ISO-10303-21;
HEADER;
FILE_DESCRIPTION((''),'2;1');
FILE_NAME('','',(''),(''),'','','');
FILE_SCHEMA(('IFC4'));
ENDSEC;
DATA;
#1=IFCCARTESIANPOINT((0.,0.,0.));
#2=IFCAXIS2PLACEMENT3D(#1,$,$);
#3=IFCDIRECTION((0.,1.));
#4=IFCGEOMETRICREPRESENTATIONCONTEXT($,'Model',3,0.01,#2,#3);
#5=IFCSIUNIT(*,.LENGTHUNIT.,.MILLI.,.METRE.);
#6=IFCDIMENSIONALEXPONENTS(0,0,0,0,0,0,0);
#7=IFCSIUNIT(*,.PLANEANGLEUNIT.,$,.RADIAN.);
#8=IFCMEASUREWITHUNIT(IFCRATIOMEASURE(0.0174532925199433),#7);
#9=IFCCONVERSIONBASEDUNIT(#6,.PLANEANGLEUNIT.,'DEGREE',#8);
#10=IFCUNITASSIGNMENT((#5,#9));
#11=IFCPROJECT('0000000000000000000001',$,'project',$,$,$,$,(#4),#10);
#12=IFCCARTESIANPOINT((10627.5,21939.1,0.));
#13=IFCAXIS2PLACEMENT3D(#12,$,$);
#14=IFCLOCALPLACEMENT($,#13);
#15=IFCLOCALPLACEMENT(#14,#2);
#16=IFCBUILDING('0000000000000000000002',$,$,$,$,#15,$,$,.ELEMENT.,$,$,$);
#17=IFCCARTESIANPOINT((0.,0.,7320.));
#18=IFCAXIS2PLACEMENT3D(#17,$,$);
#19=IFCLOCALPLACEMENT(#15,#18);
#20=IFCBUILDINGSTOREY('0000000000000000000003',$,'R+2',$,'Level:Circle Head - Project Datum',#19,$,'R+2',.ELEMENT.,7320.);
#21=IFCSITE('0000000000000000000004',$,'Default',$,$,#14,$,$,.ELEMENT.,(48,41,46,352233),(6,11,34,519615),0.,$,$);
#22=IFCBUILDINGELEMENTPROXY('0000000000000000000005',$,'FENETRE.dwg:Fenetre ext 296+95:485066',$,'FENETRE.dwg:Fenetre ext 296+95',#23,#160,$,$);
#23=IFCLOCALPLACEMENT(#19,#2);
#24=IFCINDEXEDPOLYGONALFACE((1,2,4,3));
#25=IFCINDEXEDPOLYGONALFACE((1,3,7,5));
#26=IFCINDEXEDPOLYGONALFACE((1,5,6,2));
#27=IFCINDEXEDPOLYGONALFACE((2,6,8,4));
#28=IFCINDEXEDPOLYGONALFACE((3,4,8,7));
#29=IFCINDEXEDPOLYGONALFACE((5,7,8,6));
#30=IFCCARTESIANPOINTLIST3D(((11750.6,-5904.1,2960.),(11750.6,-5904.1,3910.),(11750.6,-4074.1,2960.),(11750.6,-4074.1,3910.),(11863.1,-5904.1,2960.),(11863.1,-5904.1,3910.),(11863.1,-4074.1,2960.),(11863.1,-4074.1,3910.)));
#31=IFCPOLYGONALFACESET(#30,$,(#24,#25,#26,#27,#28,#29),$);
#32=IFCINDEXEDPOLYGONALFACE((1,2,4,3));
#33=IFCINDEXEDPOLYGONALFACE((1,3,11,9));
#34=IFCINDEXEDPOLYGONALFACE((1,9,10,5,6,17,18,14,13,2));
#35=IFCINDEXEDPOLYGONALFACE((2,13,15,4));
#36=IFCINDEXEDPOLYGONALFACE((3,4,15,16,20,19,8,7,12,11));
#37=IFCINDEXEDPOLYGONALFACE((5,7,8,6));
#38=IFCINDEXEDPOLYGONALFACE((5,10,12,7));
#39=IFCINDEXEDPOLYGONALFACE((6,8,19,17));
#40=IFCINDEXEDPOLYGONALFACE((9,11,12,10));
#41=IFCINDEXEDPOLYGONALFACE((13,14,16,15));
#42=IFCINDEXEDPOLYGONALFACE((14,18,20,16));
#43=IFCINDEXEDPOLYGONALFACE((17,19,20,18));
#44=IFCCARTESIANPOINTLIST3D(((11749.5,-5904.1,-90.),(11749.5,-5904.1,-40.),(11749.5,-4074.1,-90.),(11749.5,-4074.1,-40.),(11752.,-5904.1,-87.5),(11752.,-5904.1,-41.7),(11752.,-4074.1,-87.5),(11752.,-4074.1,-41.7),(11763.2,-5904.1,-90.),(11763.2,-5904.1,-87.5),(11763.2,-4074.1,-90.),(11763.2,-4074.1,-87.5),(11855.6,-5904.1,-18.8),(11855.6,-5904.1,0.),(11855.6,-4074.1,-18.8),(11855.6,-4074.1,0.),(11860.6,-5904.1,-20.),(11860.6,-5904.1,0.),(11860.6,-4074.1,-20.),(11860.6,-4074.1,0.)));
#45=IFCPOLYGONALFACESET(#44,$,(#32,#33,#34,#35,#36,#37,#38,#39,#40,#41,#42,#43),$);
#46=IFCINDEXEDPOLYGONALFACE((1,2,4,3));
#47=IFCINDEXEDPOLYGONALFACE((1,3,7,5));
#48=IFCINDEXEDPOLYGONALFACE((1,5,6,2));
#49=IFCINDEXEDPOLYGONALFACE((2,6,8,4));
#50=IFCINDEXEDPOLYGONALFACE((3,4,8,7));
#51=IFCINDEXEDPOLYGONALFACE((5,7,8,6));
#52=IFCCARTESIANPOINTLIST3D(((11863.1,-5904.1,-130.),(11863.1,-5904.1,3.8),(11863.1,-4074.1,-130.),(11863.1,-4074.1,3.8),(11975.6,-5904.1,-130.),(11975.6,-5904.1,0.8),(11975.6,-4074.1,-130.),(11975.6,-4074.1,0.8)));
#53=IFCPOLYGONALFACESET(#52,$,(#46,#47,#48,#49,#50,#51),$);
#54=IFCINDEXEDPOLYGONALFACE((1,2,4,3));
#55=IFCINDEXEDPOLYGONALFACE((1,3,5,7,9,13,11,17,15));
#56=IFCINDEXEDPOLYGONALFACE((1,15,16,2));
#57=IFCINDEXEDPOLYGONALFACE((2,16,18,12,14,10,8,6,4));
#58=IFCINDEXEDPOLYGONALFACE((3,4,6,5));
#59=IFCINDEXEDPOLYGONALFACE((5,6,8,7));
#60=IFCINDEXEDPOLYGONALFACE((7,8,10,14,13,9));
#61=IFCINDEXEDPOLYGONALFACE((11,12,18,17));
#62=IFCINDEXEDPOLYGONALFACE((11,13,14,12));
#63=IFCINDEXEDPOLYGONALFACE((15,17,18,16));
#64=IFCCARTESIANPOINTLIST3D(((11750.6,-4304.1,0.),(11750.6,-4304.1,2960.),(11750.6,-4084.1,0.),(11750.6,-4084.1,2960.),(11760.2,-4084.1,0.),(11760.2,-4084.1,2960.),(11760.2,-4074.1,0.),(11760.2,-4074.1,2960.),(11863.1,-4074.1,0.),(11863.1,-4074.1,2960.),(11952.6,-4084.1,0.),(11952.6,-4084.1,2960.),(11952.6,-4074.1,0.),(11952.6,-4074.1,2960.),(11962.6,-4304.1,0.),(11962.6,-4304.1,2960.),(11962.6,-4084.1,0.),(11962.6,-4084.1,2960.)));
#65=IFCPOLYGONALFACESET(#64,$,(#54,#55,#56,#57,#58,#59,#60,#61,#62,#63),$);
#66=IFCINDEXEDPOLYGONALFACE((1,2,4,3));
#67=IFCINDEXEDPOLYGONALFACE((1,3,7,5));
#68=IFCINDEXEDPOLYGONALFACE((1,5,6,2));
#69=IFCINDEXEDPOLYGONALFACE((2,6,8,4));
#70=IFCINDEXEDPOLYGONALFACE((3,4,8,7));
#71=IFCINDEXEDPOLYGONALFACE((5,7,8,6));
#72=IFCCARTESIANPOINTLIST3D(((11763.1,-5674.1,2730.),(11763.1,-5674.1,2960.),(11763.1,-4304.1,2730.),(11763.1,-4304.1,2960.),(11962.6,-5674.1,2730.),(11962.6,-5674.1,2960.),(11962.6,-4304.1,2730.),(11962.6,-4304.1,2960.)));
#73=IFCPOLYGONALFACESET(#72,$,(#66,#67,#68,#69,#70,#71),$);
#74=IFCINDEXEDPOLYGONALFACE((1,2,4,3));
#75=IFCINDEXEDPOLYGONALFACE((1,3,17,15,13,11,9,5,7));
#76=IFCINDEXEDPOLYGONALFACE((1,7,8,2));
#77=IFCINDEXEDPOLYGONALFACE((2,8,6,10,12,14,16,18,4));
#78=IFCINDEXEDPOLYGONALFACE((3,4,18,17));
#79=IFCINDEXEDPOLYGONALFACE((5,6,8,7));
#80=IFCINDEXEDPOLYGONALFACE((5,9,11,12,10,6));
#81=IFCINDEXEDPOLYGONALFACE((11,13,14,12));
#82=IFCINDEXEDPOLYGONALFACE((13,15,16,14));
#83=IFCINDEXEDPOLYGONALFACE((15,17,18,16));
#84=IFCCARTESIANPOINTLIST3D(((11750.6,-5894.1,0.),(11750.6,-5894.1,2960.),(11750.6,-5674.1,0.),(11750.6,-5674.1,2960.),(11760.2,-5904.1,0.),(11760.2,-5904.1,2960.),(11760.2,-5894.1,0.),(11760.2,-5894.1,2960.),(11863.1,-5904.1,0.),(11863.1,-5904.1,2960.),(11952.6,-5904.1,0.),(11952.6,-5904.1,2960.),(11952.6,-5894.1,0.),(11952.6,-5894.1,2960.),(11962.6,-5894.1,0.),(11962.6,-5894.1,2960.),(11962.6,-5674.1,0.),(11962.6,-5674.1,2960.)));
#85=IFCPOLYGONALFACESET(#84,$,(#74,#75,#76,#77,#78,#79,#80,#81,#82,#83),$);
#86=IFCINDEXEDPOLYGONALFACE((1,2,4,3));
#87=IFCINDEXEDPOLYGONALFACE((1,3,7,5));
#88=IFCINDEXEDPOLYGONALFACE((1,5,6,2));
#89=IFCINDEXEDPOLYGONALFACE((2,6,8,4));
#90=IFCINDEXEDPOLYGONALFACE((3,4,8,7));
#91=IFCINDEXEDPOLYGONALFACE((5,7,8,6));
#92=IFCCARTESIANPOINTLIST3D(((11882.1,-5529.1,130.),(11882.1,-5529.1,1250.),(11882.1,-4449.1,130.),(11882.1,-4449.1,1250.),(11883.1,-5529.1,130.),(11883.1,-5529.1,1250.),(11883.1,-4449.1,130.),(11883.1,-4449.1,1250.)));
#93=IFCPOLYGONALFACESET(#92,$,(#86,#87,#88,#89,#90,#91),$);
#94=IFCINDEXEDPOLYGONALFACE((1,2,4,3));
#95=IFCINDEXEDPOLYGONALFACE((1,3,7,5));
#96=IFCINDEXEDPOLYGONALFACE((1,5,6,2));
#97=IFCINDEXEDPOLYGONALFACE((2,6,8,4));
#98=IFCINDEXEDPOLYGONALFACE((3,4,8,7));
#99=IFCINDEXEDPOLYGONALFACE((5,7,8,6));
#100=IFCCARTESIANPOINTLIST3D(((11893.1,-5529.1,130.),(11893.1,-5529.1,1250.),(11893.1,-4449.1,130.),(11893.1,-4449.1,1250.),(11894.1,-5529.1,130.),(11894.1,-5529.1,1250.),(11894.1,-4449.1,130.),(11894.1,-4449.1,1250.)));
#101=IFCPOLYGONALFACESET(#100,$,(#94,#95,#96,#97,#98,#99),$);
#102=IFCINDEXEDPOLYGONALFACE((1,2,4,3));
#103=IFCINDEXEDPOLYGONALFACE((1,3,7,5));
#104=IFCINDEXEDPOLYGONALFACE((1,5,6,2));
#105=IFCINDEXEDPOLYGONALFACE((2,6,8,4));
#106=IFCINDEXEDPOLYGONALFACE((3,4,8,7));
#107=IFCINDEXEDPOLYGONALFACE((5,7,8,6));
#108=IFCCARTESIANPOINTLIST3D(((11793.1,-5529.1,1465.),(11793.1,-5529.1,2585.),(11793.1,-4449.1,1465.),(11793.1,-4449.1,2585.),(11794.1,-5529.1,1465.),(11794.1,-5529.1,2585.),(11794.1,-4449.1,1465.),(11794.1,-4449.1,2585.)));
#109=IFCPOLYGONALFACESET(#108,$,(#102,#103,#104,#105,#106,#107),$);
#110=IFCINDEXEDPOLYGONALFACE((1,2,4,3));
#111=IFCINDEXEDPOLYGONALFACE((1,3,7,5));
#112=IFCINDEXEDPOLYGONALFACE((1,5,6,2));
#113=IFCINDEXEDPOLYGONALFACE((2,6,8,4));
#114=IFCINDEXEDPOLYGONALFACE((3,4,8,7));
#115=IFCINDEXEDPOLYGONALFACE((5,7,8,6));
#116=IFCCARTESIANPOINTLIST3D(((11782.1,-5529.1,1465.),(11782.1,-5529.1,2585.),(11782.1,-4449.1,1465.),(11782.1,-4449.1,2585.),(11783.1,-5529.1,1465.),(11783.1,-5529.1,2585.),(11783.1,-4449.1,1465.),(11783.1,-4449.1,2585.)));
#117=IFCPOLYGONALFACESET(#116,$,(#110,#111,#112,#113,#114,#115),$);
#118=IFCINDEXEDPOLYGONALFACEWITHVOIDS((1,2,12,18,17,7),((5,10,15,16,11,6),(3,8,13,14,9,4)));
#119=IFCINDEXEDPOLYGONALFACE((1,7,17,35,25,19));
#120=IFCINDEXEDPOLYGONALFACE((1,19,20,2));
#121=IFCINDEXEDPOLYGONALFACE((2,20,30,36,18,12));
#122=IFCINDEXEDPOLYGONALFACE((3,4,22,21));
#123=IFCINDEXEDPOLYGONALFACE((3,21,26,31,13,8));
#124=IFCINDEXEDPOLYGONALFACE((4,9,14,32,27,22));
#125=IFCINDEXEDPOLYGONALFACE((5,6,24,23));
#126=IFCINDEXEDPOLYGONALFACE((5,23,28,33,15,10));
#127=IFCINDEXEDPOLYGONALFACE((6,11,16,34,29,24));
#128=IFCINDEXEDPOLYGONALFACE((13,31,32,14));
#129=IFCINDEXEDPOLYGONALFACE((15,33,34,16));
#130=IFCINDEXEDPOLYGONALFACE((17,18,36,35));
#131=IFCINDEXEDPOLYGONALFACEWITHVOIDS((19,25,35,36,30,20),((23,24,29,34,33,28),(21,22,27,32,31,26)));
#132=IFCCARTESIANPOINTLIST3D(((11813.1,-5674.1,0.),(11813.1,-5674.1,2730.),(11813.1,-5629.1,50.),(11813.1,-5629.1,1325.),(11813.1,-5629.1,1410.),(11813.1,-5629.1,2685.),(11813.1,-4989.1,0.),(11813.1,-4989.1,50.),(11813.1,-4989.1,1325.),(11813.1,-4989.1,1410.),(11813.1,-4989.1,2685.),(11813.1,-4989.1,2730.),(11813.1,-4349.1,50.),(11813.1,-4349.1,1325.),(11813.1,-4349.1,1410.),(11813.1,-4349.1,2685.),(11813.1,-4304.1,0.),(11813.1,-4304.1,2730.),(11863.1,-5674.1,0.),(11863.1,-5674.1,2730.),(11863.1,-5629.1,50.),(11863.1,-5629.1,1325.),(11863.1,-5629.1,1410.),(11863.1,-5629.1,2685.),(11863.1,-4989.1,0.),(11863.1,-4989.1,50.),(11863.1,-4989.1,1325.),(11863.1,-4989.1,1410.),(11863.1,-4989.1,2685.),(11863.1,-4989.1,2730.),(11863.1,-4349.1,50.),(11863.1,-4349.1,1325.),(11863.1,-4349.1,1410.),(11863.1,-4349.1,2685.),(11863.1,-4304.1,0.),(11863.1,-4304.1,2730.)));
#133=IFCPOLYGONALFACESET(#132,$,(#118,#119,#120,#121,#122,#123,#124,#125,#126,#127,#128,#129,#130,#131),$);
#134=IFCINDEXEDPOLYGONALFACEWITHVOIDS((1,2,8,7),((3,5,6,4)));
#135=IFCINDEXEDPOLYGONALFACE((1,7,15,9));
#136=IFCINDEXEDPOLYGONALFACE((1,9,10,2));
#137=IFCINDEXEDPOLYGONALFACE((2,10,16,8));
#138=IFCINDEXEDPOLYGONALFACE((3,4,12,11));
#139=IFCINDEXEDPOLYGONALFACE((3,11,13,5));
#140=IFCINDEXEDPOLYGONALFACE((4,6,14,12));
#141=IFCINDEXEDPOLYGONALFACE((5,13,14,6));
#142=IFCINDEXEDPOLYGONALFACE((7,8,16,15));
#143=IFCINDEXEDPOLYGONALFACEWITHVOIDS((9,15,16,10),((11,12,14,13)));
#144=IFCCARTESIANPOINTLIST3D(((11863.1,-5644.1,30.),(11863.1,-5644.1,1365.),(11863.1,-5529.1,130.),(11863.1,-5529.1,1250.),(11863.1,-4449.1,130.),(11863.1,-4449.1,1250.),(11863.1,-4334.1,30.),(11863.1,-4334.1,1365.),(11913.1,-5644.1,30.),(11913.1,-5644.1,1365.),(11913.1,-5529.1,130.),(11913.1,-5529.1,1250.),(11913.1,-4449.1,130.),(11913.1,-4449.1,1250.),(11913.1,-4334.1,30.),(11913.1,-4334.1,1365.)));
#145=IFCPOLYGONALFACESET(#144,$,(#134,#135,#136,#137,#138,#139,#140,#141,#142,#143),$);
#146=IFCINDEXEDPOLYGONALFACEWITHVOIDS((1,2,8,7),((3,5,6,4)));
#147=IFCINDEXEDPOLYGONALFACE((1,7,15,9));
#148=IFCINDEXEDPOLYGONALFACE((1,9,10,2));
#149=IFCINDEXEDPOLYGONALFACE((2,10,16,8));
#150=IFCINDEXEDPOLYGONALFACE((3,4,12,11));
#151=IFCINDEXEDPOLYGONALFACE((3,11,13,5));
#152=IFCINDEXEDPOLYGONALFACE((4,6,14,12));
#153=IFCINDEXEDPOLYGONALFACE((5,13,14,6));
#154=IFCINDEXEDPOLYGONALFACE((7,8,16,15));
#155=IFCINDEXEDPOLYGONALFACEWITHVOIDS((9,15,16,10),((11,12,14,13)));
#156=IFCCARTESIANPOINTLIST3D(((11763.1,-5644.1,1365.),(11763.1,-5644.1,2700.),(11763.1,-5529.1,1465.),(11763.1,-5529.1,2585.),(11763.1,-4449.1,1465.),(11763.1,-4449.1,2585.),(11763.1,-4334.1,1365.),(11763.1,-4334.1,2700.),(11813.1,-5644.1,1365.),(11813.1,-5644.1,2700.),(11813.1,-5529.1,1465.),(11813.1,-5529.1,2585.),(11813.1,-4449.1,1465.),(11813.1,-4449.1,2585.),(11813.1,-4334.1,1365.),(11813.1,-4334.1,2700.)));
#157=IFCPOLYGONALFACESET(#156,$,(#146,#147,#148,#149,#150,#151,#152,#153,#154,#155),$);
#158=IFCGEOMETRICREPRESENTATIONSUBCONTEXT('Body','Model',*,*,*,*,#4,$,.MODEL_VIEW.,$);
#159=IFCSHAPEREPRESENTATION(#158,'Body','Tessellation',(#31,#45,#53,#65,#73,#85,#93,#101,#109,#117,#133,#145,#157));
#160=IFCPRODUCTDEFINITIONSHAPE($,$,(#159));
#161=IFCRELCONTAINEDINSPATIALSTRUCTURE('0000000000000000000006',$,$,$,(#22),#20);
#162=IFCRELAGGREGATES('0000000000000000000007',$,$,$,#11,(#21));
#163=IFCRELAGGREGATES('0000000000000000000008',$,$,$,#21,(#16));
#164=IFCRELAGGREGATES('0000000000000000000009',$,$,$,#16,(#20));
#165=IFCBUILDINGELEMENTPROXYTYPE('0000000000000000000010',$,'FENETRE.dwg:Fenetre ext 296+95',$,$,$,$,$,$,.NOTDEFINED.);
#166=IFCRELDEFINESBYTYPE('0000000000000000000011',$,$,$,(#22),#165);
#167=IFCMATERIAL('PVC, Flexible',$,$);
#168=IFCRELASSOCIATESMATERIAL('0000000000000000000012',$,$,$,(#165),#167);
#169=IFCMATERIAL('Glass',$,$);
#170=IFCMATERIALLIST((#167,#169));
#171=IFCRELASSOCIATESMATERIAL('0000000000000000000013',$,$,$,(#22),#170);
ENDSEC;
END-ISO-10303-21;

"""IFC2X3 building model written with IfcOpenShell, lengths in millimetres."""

from ifc_helpers import new_model, entity, si_unit, converted_unit, direction, frame, frame_2d, origin, origin_2d_with_axis, place, context, subcontext, project, spatial, polyline, rectangle, outline, extrude, source, transform, mapped, material, material_list, type_object, type_shapes, element, save


model = new_model("IFC2X3")

# Units and contexts
model_context = context("Model", 3, precision=0.01, world=origin(), true_north=direction((0.0, 1.0)))
body_context = subcontext(model_context, "Body", "Model", "MODEL_VIEW")
ifc_project = project(units=[si_unit("LENGTHUNIT", "METRE", prefix="MILLI"), converted_unit("PLANEANGLEUNIT", "DEGREE", entity("IfcRatioMeasure", 0.0174532925199433), si_unit("PLANEANGLEUNIT", "RADIAN"), dimensions=[0, 0, 0, 0, 0, 0, 0])], contexts=[model_context])

# Site, building, storey
site_placement = place(None, frame((10627.5, 21939.1, 0.0)))
site = spatial("IfcSite", under=ifc_project, at=site_placement, Name="Default", CompositionType="ELEMENT", RefLatitude=(48, 41, 46, 352233), RefLongitude=(6, 11, 34, 519615), RefElevation=0.0)
building_placement = place(site_placement, origin())
building = spatial("IfcBuilding", under=site, at=building_placement, CompositionType="ELEMENT")
storey_placement = place(building_placement, frame((0.0, 0.0, 7320.0)))
storey = spatial("IfcBuildingStorey", under=building, at=storey_placement, Name="R+2", ObjectType="Level:Circle Head - Project Datum", LongName="R+2", CompositionType="ELEMENT", Elevation=7320.0)

# Building element proxy
ifc_material_1 = material(Name="PVC, Flexible")
ifc_material_2 = material(Name="Glass")
building_element_proxy_type_1 = type_object("IfcBuildingElementProxyType", Name="FENETRE.dwg:Fenetre ext 296+95", PredefinedType="NOTDEFINED", material=ifc_material_1)
shared_shape_1 = source(origin(), body_context, "Body", "SweptSolid", [
    extrude(rectangle(XDim=1830.0, YDim=112.5, at=origin_2d_with_axis()), frame((-10.4, 56.3, 2960.0), z_axis=(0.0, 0.0, 1.0), x_axis=(-1.0, 0.0, 0.0)), (0.0, 0.0, 1.0), 950.0),
    extrude(outline(polyline([(-68.6, -14.4), (-72.5, -34.0), (-67.6, -35.0), (-63.9, -16.6), (44.3, -16.6), (54.1, 32.5), (40.6, 35.2), (40.1, 32.7), (51.2, 30.5), (42.2, -14.4), (-68.6, -14.4)])), frame((-925.4, 66.9, -47.5), z_axis=(-1.0, 0.0, 0.0), x_axis=(0.0, 0.980599, -0.196027)), (0.0, 0.0, -1.0), 1830.0),
    extrude(outline(polyline([(-64.7, -56.3), (66.2, -56.3), (66.2, 56.3), (-67.7, 56.3), (-64.7, -56.3)])), frame((-925.4, -56.3, -63.8), z_axis=(1.0, 0.0, 0.0), x_axis=(0.0, 0.0, -1.0)), (0.0, 0.0, 1.0), 1830.0),
    extrude(outline(polyline([(-55.6, 97.0), (-55.6, -5.9), (-55.6, -95.4), (-45.6, -95.4), (-45.6, -105.4), (174.4, -105.4), (174.4, 106.6), (-45.6, 106.6), (-45.6, 97.0), (-55.6, 97.0)])), frame((849.0, 5.9, 0.0), z_axis=(0.0, 0.0, -1.0), x_axis=(-1.0, 0.0, 0.0)), (0.0, 0.0, -1.0), 2960.0),
    extrude(rectangle(XDim=199.5, YDim=1370.0, at=origin_2d_with_axis()), frame((-10.4, 0.3, 2730.0), z_axis=(0.0, 0.0, 1.0), x_axis=(0.0, 1.0, 0.0)), (0.0, 0.0, 1.0), 230.0),
    extrude(outline(polyline([(-97.0, -55.6), (5.9, -55.6), (95.4, -55.6), (95.4, -45.6), (105.4, -45.6), (105.4, 174.4), (-106.6, 174.4), (-106.6, -45.6), (-97.0, -45.6), (-97.0, -55.6)])), frame((-869.9, 5.9, 0.0), z_axis=(0.0, 0.0, 1.0), x_axis=(0.0, -1.0, 0.0)), (0.0, 0.0, 1.0), 2960.0),
    extrude(rectangle(XDim=1.0, YDim=1080.0, at=origin_2d_with_axis()), frame((-10.4, -19.5, 130.0), z_axis=(0.0, 0.0, 1.0), x_axis=(0.0, 1.0, 0.0)), (0.0, 0.0, 1.0), 1120.0),
    extrude(rectangle(XDim=1.0, YDim=1080.0, at=frame_2d((0.0, 0.0), x_axis=(1.0, 0.0))), frame((-10.4, -30.5, 130.0), z_axis=(0.0, 0.0, 1.0), x_axis=(0.0, 1.0, 0.0)), (0.0, 0.0, 1.0), 1120.0),
    extrude(rectangle(XDim=1.0, YDim=1080.0, at=frame_2d((0.0, 0.0), x_axis=(1.0, 0.0))), frame((-10.4, 69.5, 1465.0), z_axis=(0.0, 0.0, 1.0), x_axis=(0.0, 1.0, 0.0)), (0.0, 0.0, 1.0), 1120.0),
    extrude(rectangle(XDim=1.0, YDim=1080.0, at=frame_2d((0.0, 0.0), x_axis=(1.0, 0.0))), frame((-10.4, 80.5, 1465.0), z_axis=(0.0, 0.0, 1.0), x_axis=(0.0, 1.0, 0.0)), (0.0, 0.0, 1.0), 1120.0),
    extrude(outline(polyline([(-685.0, -1365.0), (0.0, -1365.0), (685.0, -1365.0), (685.0, 1365.0), (0.0, 1365.0), (-685.0, 1365.0), (-685.0, -1365.0)]), holes=[polyline([(-640.0, -1320.0), (-640.0, -45.0), (0.0, -45.0), (640.0, -45.0), (640.0, -1320.0), (0.0, -1320.0), (-640.0, -1320.0)]), polyline([(-640.0, 40.0), (-640.0, 1315.0), (0.0, 1315.0), (640.0, 1315.0), (640.0, 40.0), (0.0, 40.0), (-640.0, 40.0)])]), frame((-10.4, 0.0, 1365.0), z_axis=(0.0, 1.0, 0.0), x_axis=(1.0, 0.0, 0.0)), (0.0, 0.0, 1.0), 50.0),
    extrude(outline(polyline([(-655.0, -667.5), (655.0, -667.5), (655.0, 667.5), (-655.0, 667.5), (-655.0, -667.5)]), holes=[polyline([(-540.0, 552.5), (540.0, 552.5), (540.0, -567.5), (-540.0, -567.5), (-540.0, 552.5)])]), frame((-10.4, -50.0, 697.5), z_axis=(0.0, 1.0, 0.0), x_axis=(-1.0, 0.0, 0.0)), (0.0, 0.0, 1.0), 50.0),
    extrude(outline(polyline([(-655.0, -667.5), (655.0, -667.5), (655.0, 667.5), (-655.0, 667.5), (-655.0, -667.5)]), holes=[polyline([(-540.0, 552.5), (540.0, 552.5), (540.0, -567.5), (-540.0, -567.5), (-540.0, 552.5)])]), frame((-10.4, 50.0, 2032.5), z_axis=(0.0, 1.0, 0.0), x_axis=(-1.0, 0.0, 0.0)), (0.0, 0.0, 1.0), 50.0),
])
type_shapes(building_element_proxy_type_1, [shared_shape_1])
ifc_material_list_1 = material_list([ifc_material_1, ifc_material_2])
proxy_1_placement = place(storey_placement, frame((11863.1, -4978.7, 0.0), z_axis=(0.0, 0.0, 1.0), x_axis=(0.0, 1.0, 0.0)))
element("IfcBuildingElementProxy", 1, at=proxy_1_placement, inside=storey, type_object=building_element_proxy_type_1, material=ifc_material_list_1, Name="FENETRE.dwg:Fenetre ext 296+95:485066", ObjectType="FENETRE.dwg:Fenetre ext 296+95", context=body_context, shape_type="MappedRepresentation", body=[
    mapped(shared_shape_1, transform((0.0, 0.0, 0.0), scale=1.0)),
])

save(model, "model.ifc")
